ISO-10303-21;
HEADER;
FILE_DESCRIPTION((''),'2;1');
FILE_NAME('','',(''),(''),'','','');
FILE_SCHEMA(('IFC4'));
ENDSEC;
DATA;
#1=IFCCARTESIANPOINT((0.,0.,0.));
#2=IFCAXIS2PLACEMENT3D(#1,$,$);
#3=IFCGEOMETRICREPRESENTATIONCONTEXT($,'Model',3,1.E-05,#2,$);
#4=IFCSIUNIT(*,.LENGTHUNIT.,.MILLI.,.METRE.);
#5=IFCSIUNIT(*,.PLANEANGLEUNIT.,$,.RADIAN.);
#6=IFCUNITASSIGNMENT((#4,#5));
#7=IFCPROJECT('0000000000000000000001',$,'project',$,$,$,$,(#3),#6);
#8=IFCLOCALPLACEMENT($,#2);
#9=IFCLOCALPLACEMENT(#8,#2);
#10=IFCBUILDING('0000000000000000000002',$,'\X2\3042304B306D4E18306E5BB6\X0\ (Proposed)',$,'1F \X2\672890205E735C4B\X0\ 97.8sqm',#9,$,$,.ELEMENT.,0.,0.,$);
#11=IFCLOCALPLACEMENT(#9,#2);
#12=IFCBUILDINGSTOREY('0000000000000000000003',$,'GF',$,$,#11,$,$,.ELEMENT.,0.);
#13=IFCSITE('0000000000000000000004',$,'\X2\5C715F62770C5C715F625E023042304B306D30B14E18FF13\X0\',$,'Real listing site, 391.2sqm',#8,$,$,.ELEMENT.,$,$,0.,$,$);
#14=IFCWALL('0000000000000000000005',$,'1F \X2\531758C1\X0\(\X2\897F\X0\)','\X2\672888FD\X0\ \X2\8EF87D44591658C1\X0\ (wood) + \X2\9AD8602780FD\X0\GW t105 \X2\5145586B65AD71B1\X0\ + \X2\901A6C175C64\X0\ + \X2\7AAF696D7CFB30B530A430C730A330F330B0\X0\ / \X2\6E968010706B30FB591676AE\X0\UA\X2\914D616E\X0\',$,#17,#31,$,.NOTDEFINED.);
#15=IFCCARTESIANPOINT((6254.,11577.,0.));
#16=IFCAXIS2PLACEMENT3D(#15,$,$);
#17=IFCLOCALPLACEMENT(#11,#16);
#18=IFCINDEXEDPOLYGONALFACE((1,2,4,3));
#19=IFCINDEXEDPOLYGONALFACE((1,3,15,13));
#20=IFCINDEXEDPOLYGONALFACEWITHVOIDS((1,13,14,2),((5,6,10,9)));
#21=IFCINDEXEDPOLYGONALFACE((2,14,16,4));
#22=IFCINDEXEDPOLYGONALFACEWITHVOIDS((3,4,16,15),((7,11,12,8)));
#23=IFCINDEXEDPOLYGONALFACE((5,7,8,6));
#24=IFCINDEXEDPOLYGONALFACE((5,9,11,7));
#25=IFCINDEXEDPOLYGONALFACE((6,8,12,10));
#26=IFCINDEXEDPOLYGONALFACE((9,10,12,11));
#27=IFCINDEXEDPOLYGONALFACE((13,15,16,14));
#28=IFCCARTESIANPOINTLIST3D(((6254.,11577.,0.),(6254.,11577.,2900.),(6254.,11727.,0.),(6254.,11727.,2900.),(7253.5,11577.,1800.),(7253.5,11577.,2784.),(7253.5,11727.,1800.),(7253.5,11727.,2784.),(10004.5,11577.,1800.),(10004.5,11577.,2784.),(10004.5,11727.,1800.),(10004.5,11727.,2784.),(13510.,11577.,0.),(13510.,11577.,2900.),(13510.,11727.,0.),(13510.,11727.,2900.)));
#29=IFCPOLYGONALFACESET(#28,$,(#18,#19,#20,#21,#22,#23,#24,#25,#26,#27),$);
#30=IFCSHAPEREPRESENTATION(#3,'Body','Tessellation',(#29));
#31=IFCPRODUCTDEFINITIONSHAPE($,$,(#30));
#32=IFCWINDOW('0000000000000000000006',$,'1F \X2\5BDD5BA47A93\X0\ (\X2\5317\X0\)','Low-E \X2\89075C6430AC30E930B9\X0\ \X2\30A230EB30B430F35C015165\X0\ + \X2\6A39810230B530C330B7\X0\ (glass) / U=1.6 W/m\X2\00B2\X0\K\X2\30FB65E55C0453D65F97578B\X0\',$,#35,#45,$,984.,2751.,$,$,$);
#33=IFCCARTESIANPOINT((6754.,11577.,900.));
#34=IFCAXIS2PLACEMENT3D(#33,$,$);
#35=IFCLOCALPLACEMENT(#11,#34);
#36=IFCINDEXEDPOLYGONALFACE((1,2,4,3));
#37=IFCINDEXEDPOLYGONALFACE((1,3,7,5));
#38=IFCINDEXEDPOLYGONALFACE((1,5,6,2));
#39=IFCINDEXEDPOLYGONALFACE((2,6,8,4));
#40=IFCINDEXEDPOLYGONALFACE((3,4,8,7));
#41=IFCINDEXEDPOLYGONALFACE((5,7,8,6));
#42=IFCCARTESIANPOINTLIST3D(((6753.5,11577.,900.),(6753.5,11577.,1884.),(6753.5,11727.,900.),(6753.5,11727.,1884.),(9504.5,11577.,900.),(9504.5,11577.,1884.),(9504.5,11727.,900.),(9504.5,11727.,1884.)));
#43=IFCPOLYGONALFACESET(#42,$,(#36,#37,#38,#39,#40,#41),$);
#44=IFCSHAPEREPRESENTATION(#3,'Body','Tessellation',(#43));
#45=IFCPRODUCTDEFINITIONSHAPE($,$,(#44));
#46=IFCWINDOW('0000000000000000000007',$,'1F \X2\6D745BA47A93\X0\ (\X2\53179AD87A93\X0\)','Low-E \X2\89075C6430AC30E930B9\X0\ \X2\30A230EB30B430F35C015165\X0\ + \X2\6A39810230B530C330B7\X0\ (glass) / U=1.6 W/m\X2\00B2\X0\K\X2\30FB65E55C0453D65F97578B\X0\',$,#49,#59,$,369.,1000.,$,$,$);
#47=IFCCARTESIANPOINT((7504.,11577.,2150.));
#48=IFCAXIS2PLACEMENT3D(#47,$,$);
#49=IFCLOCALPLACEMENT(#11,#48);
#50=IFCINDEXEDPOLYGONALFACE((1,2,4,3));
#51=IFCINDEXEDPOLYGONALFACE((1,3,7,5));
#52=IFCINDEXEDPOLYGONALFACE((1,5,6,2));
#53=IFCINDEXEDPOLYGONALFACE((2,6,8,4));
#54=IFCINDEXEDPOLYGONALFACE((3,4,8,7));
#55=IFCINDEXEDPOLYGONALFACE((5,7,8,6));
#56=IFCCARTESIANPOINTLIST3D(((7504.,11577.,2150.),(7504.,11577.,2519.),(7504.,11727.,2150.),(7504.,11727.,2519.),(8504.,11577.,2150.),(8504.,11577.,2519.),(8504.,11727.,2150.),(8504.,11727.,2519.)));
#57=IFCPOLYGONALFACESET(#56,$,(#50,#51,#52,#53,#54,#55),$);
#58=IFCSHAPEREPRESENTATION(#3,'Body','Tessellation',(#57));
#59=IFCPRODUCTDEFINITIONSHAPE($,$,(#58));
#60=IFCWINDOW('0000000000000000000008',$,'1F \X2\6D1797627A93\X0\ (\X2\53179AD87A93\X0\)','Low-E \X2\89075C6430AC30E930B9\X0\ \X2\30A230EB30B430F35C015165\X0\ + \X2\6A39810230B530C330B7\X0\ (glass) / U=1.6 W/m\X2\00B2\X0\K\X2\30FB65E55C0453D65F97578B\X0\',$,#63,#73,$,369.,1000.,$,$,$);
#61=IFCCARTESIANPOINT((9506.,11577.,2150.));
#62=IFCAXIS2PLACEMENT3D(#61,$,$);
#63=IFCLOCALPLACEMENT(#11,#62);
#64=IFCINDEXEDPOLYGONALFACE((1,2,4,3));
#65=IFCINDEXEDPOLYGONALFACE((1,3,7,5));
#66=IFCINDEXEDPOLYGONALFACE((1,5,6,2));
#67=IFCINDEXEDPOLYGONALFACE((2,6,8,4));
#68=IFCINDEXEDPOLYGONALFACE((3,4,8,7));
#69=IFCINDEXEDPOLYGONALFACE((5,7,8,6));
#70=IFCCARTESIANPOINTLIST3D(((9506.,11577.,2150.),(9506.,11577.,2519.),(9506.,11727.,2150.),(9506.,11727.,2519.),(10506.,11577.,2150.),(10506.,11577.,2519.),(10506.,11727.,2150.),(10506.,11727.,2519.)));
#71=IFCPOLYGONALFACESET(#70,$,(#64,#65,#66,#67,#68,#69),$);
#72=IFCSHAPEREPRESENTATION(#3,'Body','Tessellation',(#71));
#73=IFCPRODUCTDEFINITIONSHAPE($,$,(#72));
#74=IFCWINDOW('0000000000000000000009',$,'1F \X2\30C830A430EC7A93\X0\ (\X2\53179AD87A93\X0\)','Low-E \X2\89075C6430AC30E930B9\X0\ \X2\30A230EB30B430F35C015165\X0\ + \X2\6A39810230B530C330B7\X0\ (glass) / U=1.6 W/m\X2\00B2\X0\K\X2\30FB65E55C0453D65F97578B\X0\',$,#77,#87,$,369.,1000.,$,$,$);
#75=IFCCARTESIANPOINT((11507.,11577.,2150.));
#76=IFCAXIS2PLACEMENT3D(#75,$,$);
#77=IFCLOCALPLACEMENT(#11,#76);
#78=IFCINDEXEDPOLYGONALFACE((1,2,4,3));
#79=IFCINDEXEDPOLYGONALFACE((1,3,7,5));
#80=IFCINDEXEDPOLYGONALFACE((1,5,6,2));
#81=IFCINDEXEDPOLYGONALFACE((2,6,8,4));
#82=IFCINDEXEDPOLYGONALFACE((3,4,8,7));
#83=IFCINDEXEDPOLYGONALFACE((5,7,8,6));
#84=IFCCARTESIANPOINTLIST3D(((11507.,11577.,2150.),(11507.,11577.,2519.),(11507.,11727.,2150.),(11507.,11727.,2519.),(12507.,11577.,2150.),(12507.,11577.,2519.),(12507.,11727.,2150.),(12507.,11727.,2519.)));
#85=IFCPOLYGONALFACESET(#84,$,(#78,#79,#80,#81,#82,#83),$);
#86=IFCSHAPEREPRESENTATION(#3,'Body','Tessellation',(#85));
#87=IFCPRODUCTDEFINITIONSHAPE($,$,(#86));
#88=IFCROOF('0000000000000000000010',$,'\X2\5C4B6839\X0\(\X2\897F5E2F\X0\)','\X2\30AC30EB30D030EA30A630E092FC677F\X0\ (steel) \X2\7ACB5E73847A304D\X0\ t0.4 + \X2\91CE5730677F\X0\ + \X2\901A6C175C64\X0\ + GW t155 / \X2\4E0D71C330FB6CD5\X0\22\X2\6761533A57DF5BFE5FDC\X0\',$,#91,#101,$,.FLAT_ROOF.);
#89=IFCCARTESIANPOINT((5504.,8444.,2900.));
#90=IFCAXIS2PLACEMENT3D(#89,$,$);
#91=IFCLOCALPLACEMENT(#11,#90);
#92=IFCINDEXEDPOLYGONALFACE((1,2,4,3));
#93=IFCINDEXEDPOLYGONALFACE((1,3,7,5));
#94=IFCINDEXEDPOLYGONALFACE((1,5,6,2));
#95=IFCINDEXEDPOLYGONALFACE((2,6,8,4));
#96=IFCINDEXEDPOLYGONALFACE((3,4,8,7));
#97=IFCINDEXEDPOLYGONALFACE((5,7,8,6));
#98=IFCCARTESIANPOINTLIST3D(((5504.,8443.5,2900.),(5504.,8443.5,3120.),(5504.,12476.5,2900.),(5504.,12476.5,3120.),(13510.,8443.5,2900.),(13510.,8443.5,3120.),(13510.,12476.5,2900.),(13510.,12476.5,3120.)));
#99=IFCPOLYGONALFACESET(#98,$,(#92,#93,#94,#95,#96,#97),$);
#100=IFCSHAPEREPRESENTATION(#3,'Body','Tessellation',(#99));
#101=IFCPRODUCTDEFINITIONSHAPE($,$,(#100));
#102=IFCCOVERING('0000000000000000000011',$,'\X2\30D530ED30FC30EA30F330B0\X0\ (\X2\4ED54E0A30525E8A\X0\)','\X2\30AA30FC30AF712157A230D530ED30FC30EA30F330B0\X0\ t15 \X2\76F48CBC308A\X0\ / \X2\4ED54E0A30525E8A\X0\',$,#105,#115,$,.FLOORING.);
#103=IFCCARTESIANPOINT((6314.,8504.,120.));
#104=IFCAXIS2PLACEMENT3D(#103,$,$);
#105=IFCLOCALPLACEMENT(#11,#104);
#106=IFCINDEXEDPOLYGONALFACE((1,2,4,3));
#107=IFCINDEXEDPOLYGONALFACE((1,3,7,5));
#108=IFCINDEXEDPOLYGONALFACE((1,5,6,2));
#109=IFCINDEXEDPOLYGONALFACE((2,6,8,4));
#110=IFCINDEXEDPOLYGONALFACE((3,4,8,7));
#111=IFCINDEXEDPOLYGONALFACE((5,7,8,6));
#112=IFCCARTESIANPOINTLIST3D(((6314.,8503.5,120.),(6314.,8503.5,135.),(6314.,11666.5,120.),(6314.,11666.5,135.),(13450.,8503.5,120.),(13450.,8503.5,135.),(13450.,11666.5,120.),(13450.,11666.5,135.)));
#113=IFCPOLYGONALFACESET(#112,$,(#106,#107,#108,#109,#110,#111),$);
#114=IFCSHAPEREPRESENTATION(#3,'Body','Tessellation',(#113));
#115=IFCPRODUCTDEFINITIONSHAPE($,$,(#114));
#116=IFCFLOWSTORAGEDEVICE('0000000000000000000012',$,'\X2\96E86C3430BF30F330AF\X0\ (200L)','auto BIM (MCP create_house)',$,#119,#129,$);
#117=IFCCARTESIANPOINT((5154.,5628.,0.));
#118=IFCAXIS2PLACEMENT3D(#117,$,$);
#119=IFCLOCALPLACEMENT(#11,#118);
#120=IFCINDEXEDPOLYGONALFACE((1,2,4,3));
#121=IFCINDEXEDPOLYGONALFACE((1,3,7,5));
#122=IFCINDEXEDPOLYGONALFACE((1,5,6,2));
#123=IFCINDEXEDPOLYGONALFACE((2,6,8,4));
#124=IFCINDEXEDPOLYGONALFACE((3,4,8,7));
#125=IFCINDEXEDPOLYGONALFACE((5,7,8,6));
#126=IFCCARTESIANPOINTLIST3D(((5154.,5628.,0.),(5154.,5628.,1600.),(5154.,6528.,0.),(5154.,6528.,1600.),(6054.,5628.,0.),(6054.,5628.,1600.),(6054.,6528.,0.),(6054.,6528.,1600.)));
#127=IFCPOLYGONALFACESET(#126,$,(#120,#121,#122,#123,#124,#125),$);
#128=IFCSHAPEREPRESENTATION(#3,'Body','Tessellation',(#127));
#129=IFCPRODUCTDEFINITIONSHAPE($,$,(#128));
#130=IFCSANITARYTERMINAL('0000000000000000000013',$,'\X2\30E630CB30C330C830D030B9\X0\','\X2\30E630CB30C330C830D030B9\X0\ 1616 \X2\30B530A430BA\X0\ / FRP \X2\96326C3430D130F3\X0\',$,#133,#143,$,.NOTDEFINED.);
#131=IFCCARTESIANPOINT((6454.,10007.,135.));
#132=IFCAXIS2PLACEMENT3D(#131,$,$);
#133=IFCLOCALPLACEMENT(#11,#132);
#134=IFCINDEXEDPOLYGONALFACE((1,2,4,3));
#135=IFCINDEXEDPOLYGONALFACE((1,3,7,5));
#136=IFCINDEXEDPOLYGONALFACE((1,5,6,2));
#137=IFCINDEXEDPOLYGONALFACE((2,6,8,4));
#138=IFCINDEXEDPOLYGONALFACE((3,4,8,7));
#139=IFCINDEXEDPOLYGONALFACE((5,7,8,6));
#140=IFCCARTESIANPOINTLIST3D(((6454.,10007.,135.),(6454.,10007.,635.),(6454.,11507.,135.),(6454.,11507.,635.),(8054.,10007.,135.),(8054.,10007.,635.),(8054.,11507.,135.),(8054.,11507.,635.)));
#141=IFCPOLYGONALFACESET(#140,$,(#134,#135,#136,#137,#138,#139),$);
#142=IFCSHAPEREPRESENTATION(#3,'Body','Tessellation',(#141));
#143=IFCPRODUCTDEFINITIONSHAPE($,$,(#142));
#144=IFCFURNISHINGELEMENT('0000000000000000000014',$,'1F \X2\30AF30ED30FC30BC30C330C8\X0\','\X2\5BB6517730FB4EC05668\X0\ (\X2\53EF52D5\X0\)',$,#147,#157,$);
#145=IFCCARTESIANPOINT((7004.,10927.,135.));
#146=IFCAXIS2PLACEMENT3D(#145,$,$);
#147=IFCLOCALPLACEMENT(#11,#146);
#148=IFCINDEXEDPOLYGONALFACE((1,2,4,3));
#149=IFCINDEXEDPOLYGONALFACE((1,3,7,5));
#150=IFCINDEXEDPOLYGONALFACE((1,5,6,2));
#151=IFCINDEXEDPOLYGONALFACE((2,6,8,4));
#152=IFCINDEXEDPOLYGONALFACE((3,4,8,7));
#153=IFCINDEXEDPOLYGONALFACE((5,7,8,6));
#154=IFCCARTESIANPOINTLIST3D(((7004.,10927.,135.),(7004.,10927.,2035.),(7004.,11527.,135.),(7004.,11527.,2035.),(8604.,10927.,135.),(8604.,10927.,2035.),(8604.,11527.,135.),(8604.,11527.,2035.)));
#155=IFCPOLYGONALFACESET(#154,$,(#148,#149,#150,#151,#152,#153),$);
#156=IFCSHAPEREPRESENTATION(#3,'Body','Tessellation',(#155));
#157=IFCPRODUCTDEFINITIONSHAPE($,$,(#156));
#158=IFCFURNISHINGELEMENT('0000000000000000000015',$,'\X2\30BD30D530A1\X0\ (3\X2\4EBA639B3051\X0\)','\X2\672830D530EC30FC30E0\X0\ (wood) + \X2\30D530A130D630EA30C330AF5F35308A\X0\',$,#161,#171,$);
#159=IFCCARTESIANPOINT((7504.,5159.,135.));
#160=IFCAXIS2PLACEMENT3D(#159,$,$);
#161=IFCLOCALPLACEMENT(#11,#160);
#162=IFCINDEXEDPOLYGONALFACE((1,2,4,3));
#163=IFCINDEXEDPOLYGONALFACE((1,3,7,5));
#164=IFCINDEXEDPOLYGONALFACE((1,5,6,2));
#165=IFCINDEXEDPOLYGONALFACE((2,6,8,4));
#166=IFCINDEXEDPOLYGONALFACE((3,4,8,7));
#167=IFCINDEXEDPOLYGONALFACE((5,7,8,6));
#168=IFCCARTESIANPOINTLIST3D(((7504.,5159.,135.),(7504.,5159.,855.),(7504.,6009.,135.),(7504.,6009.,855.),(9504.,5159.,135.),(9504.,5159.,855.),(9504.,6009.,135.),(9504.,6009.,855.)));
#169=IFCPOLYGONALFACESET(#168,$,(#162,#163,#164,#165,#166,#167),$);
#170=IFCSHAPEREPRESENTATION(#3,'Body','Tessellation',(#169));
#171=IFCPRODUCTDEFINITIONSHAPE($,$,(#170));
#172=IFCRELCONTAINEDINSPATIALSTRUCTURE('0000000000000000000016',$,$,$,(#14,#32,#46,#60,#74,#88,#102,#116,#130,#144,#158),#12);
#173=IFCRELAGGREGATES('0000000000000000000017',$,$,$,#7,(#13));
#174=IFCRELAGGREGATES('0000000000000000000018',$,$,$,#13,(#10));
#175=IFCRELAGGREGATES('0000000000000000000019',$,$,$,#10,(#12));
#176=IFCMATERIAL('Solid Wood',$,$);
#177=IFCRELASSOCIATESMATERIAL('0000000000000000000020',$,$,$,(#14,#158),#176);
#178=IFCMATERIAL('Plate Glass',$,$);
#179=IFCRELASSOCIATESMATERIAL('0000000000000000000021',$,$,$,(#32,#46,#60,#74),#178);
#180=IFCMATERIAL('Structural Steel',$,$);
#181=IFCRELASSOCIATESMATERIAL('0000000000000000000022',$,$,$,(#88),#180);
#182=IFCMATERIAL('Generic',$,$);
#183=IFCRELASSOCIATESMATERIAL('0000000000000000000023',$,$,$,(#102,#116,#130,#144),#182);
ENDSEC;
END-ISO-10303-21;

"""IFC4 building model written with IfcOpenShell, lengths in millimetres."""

from ifc_helpers import new_model, si_unit, frame, frame_2d, origin, place, context, project, spatial, rectangle, extrude, material, element, fill, save


model = new_model("IFC4")

# Units and contexts
model_context = context("Model", 3, precision=1e-05, world=origin())
ifc_project = project(units=[si_unit("LENGTHUNIT", "METRE", prefix="MILLI"), si_unit("PLANEANGLEUNIT", "RADIAN")], contexts=[model_context])

# Site, building, storey
site_placement = place(None, origin())
site = spatial("IfcSite", under=ifc_project, at=site_placement, Name="山形県山形市あかねケ丘３", ObjectType="Real listing site, 391.2sqm", CompositionType="ELEMENT", RefElevation=0.0)
building_placement = place(site_placement, origin())
building = spatial("IfcBuilding", under=site, at=building_placement, Name="あかね丘の家 (Proposed)", ObjectType="1F 木造平屋 97.8sqm", CompositionType="ELEMENT", ElevationOfRefHeight=0.0, ElevationOfTerrain=0.0)
storey_placement = place(building_placement, origin())
storey = spatial("IfcBuildingStorey", under=building, at=storey_placement, Name="GF", CompositionType="ELEMENT", Elevation=0.0)

# Shared definitions
ifc_material_1 = material(Name="Solid Wood")

# Shared definitions
ifc_material_2 = material(Name="Plate Glass")

# Wall, openings, windows
wall_1_placement = place(storey_placement, frame((6254.0, 11577.0, 0.0)))
wall_1 = element("IfcWall", 1, at=wall_1_placement, inside=storey, material=ifc_material_1, Name="1F 北壁(西)", Description="木製 軸組外壁 (wood) + 高性能GW t105 充填断熱 + 通気層 + 窯業系サイディング / 準耐火・外皮UA配慮", PredefinedType="NOTDEFINED", context=model_context, shape_type="SweptSolid", body=[
    extrude(rectangle(XDim=7256.0, YDim=150.0, at=frame_2d((3628.0, 75.0))), frame((6254.0, 11577.0, 0.0)), (0.0, 0.0, 1.0), 2900.0),
])
opening_1_placement = place(storey_placement, frame((6754.0, 11577.0, 900.0)))
opening_1 = element("IfcOpeningElement", 2, at=opening_1_placement, cuts=wall_1, PredefinedType="NOTDEFINED", context=model_context, shape_type="SweptSolid", body=[
    extrude(rectangle(XDim=2751.0, YDim=150.0, at=frame_2d((1375.0, 75.0))), frame((6754.0, 11577.0, 900.0)), (0.0, 0.0, 1.0), 984.0),
])
opening_2_placement = place(storey_placement, frame((7504.0, 11577.0, 2150.0)))
opening_2 = element("IfcOpeningElement", 3, at=opening_2_placement, cuts=wall_1, PredefinedType="NOTDEFINED", context=model_context, shape_type="SweptSolid", body=[
    extrude(rectangle(XDim=1000.0, YDim=150.0, at=frame_2d((500.0, 75.0))), frame((7504.0, 11577.0, 2150.0)), (0.0, 0.0, 1.0), 369.0),
])
opening_3_placement = place(storey_placement, frame((9506.0, 11577.0, 2150.0)))
opening_3 = element("IfcOpeningElement", 4, at=opening_3_placement, cuts=wall_1, PredefinedType="NOTDEFINED", context=model_context, shape_type="SweptSolid", body=[
    extrude(rectangle(XDim=1000.0, YDim=150.0, at=frame_2d((500.0, 75.0))), frame((9506.0, 11577.0, 2150.0)), (0.0, 0.0, 1.0), 369.0),
])
opening_4_placement = place(storey_placement, frame((11507.0, 11577.0, 2150.0)))
opening_4 = element("IfcOpeningElement", 5, at=opening_4_placement, cuts=wall_1, PredefinedType="NOTDEFINED", context=model_context, shape_type="SweptSolid", body=[
    extrude(rectangle(XDim=1000.0, YDim=150.0, at=frame_2d((500.0, 75.0))), frame((11507.0, 11577.0, 2150.0)), (0.0, 0.0, 1.0), 369.0),
])
window_1_placement = place(storey_placement, frame((6754.0, 11577.0, 900.0)))
window_1 = element("IfcWindow", 6, at=window_1_placement, inside=storey, material=ifc_material_2, Name="1F 寝室窓 (北)", Description="Low-E 複層ガラス アルゴン封入 + 樹脂サッシ (glass) / U=1.6 W/m²K・日射取得型", OverallHeight=984.0, OverallWidth=2751.0, context=model_context, shape_type="SweptSolid", body=[
    extrude(rectangle(XDim=2751.0, YDim=150.0, at=frame_2d((1375.0, 75.0))), frame((6754.0, 11577.0, 900.0)), (0.0, 0.0, 1.0), 984.0),
])
fill(opening_1, window_1)
window_2_placement = place(storey_placement, frame((7504.0, 11577.0, 2150.0)))
window_2 = element("IfcWindow", 7, at=window_2_placement, inside=storey, material=ifc_material_2, Name="1F 浴室窓 (北高窓)", Description="Low-E 複層ガラス アルゴン封入 + 樹脂サッシ (glass) / U=1.6 W/m²K・日射取得型", OverallHeight=369.0, OverallWidth=1000.0, context=model_context, shape_type="SweptSolid", body=[
    extrude(rectangle(XDim=1000.0, YDim=150.0, at=frame_2d((500.0, 75.0))), frame((7504.0, 11577.0, 2150.0)), (0.0, 0.0, 1.0), 369.0),
])
fill(opening_2, window_2)
window_3_placement = place(storey_placement, frame((9506.0, 11577.0, 2150.0)))
window_3 = element("IfcWindow", 8, at=window_3_placement, inside=storey, material=ifc_material_2, Name="1F 洗面窓 (北高窓)", Description="Low-E 複層ガラス アルゴン封入 + 樹脂サッシ (glass) / U=1.6 W/m²K・日射取得型", OverallHeight=369.0, OverallWidth=1000.0, context=model_context, shape_type="SweptSolid", body=[
    extrude(rectangle(XDim=1000.0, YDim=150.0, at=frame_2d((500.0, 75.0))), frame((9506.0, 11577.0, 2150.0)), (0.0, 0.0, 1.0), 369.0),
])
fill(opening_3, window_3)
window_4_placement = place(storey_placement, frame((11507.0, 11577.0, 2150.0)))
window_4 = element("IfcWindow", 9, at=window_4_placement, inside=storey, material=ifc_material_2, Name="1F トイレ窓 (北高窓)", Description="Low-E 複層ガラス アルゴン封入 + 樹脂サッシ (glass) / U=1.6 W/m²K・日射取得型", OverallHeight=369.0, OverallWidth=1000.0, context=model_context, shape_type="SweptSolid", body=[
    extrude(rectangle(XDim=1000.0, YDim=150.0, at=frame_2d((500.0, 75.0))), frame((11507.0, 11577.0, 2150.0)), (0.0, 0.0, 1.0), 369.0),
])
fill(opening_4, window_4)

# Roof
ifc_material_3 = material(Name="Structural Steel")
roof_1_placement = place(storey_placement, frame((5504.0, 8444.0, 2900.0)))
element("IfcRoof", 10, at=roof_1_placement, inside=storey, material=ifc_material_3, Name="屋根(西帯)", Description="ガルバリウム鋼板 (steel) 立平葺き t0.4 + 野地板 + 通気層 + GW t155 / 不燃・法22条区域対応", PredefinedType="FLAT_ROOF", context=model_context, shape_type="SweptSolid", body=[
    extrude(rectangle(XDim=8006.0, YDim=4033.0, at=frame_2d((4003.0, 2016.0))), frame((5504.0, 8444.0, 2900.0)), (0.0, 0.0, 1.0), 220.0),
])

# Covering
ifc_material_4 = material(Name="Generic")
covering_1_placement = place(storey_placement, frame((6314.0, 8504.0, 120.0)))
element("IfcCovering", 11, at=covering_1_placement, inside=storey, material=ifc_material_4, Name="フローリング (仕上げ床)", Description="オーク無垢フローリング t15 直貼り / 仕上げ床", PredefinedType="FLOORING", context=model_context, shape_type="SweptSolid", body=[
    extrude(rectangle(XDim=7136.0, YDim=3163.0, at=frame_2d((3568.0, 1581.0))), frame((6314.0, 8504.0, 120.0)), (0.0, 0.0, 1.0), 15.0),
])

# Flow storage device
flow_storage_device_placement = place(storey_placement, frame((5154.0, 5628.0, 0.0)))
element("IfcFlowStorageDevice", 12, at=flow_storage_device_placement, inside=storey, material=ifc_material_4, Name="雨水タンク (200L)", Description="auto BIM (MCP create_house)", context=model_context, shape_type="SweptSolid", body=[
    extrude(rectangle(XDim=900.0, YDim=900.0, at=frame_2d((450.0, 450.0))), frame((5154.0, 5628.0, 0.0)), (0.0, 0.0, 1.0), 1600.0),
])

# Sanitary terminal
sanitary_terminal_placement = place(storey_placement, frame((6454.0, 10007.0, 135.0)))
element("IfcSanitaryTerminal", 13, at=sanitary_terminal_placement, inside=storey, material=ifc_material_4, Name="ユニットバス", Description="ユニットバス 1616 サイズ / FRP 防水パン", PredefinedType="NOTDEFINED", context=model_context, shape_type="SweptSolid", body=[
    extrude(rectangle(XDim=1600.0, YDim=1500.0, at=frame_2d((800.0, 750.0))), frame((6454.0, 10007.0, 135.0)), (0.0, 0.0, 1.0), 500.0),
])

# Furnishing elements
furnishing_1_placement = place(storey_placement, frame((7004.0, 10927.0, 135.0)))
element("IfcFurnishingElement", 14, at=furnishing_1_placement, inside=storey, material=ifc_material_4, Name="1F クローゼット", Description="家具・什器 (可動)", context=model_context, shape_type="SweptSolid", body=[
    extrude(rectangle(XDim=1600.0, YDim=600.0, at=frame_2d((800.0, 300.0))), frame((7004.0, 10927.0, 135.0)), (0.0, 0.0, 1.0), 1900.0),
])
furnishing_2_placement = place(storey_placement, frame((7504.0, 5159.0, 135.0)))
element("IfcFurnishingElement", 15, at=furnishing_2_placement, inside=storey, material=ifc_material_1, Name="ソファ (3人掛け)", Description="木フレーム (wood) + ファブリック張り", context=model_context, shape_type="SweptSolid", body=[
    extrude(rectangle(XDim=2000.0, YDim=850.0, at=frame_2d((1000.0, 425.0))), frame((7504.0, 5159.0, 135.0)), (0.0, 0.0, 1.0), 720.0),
])

save(model, "model.ifc")
